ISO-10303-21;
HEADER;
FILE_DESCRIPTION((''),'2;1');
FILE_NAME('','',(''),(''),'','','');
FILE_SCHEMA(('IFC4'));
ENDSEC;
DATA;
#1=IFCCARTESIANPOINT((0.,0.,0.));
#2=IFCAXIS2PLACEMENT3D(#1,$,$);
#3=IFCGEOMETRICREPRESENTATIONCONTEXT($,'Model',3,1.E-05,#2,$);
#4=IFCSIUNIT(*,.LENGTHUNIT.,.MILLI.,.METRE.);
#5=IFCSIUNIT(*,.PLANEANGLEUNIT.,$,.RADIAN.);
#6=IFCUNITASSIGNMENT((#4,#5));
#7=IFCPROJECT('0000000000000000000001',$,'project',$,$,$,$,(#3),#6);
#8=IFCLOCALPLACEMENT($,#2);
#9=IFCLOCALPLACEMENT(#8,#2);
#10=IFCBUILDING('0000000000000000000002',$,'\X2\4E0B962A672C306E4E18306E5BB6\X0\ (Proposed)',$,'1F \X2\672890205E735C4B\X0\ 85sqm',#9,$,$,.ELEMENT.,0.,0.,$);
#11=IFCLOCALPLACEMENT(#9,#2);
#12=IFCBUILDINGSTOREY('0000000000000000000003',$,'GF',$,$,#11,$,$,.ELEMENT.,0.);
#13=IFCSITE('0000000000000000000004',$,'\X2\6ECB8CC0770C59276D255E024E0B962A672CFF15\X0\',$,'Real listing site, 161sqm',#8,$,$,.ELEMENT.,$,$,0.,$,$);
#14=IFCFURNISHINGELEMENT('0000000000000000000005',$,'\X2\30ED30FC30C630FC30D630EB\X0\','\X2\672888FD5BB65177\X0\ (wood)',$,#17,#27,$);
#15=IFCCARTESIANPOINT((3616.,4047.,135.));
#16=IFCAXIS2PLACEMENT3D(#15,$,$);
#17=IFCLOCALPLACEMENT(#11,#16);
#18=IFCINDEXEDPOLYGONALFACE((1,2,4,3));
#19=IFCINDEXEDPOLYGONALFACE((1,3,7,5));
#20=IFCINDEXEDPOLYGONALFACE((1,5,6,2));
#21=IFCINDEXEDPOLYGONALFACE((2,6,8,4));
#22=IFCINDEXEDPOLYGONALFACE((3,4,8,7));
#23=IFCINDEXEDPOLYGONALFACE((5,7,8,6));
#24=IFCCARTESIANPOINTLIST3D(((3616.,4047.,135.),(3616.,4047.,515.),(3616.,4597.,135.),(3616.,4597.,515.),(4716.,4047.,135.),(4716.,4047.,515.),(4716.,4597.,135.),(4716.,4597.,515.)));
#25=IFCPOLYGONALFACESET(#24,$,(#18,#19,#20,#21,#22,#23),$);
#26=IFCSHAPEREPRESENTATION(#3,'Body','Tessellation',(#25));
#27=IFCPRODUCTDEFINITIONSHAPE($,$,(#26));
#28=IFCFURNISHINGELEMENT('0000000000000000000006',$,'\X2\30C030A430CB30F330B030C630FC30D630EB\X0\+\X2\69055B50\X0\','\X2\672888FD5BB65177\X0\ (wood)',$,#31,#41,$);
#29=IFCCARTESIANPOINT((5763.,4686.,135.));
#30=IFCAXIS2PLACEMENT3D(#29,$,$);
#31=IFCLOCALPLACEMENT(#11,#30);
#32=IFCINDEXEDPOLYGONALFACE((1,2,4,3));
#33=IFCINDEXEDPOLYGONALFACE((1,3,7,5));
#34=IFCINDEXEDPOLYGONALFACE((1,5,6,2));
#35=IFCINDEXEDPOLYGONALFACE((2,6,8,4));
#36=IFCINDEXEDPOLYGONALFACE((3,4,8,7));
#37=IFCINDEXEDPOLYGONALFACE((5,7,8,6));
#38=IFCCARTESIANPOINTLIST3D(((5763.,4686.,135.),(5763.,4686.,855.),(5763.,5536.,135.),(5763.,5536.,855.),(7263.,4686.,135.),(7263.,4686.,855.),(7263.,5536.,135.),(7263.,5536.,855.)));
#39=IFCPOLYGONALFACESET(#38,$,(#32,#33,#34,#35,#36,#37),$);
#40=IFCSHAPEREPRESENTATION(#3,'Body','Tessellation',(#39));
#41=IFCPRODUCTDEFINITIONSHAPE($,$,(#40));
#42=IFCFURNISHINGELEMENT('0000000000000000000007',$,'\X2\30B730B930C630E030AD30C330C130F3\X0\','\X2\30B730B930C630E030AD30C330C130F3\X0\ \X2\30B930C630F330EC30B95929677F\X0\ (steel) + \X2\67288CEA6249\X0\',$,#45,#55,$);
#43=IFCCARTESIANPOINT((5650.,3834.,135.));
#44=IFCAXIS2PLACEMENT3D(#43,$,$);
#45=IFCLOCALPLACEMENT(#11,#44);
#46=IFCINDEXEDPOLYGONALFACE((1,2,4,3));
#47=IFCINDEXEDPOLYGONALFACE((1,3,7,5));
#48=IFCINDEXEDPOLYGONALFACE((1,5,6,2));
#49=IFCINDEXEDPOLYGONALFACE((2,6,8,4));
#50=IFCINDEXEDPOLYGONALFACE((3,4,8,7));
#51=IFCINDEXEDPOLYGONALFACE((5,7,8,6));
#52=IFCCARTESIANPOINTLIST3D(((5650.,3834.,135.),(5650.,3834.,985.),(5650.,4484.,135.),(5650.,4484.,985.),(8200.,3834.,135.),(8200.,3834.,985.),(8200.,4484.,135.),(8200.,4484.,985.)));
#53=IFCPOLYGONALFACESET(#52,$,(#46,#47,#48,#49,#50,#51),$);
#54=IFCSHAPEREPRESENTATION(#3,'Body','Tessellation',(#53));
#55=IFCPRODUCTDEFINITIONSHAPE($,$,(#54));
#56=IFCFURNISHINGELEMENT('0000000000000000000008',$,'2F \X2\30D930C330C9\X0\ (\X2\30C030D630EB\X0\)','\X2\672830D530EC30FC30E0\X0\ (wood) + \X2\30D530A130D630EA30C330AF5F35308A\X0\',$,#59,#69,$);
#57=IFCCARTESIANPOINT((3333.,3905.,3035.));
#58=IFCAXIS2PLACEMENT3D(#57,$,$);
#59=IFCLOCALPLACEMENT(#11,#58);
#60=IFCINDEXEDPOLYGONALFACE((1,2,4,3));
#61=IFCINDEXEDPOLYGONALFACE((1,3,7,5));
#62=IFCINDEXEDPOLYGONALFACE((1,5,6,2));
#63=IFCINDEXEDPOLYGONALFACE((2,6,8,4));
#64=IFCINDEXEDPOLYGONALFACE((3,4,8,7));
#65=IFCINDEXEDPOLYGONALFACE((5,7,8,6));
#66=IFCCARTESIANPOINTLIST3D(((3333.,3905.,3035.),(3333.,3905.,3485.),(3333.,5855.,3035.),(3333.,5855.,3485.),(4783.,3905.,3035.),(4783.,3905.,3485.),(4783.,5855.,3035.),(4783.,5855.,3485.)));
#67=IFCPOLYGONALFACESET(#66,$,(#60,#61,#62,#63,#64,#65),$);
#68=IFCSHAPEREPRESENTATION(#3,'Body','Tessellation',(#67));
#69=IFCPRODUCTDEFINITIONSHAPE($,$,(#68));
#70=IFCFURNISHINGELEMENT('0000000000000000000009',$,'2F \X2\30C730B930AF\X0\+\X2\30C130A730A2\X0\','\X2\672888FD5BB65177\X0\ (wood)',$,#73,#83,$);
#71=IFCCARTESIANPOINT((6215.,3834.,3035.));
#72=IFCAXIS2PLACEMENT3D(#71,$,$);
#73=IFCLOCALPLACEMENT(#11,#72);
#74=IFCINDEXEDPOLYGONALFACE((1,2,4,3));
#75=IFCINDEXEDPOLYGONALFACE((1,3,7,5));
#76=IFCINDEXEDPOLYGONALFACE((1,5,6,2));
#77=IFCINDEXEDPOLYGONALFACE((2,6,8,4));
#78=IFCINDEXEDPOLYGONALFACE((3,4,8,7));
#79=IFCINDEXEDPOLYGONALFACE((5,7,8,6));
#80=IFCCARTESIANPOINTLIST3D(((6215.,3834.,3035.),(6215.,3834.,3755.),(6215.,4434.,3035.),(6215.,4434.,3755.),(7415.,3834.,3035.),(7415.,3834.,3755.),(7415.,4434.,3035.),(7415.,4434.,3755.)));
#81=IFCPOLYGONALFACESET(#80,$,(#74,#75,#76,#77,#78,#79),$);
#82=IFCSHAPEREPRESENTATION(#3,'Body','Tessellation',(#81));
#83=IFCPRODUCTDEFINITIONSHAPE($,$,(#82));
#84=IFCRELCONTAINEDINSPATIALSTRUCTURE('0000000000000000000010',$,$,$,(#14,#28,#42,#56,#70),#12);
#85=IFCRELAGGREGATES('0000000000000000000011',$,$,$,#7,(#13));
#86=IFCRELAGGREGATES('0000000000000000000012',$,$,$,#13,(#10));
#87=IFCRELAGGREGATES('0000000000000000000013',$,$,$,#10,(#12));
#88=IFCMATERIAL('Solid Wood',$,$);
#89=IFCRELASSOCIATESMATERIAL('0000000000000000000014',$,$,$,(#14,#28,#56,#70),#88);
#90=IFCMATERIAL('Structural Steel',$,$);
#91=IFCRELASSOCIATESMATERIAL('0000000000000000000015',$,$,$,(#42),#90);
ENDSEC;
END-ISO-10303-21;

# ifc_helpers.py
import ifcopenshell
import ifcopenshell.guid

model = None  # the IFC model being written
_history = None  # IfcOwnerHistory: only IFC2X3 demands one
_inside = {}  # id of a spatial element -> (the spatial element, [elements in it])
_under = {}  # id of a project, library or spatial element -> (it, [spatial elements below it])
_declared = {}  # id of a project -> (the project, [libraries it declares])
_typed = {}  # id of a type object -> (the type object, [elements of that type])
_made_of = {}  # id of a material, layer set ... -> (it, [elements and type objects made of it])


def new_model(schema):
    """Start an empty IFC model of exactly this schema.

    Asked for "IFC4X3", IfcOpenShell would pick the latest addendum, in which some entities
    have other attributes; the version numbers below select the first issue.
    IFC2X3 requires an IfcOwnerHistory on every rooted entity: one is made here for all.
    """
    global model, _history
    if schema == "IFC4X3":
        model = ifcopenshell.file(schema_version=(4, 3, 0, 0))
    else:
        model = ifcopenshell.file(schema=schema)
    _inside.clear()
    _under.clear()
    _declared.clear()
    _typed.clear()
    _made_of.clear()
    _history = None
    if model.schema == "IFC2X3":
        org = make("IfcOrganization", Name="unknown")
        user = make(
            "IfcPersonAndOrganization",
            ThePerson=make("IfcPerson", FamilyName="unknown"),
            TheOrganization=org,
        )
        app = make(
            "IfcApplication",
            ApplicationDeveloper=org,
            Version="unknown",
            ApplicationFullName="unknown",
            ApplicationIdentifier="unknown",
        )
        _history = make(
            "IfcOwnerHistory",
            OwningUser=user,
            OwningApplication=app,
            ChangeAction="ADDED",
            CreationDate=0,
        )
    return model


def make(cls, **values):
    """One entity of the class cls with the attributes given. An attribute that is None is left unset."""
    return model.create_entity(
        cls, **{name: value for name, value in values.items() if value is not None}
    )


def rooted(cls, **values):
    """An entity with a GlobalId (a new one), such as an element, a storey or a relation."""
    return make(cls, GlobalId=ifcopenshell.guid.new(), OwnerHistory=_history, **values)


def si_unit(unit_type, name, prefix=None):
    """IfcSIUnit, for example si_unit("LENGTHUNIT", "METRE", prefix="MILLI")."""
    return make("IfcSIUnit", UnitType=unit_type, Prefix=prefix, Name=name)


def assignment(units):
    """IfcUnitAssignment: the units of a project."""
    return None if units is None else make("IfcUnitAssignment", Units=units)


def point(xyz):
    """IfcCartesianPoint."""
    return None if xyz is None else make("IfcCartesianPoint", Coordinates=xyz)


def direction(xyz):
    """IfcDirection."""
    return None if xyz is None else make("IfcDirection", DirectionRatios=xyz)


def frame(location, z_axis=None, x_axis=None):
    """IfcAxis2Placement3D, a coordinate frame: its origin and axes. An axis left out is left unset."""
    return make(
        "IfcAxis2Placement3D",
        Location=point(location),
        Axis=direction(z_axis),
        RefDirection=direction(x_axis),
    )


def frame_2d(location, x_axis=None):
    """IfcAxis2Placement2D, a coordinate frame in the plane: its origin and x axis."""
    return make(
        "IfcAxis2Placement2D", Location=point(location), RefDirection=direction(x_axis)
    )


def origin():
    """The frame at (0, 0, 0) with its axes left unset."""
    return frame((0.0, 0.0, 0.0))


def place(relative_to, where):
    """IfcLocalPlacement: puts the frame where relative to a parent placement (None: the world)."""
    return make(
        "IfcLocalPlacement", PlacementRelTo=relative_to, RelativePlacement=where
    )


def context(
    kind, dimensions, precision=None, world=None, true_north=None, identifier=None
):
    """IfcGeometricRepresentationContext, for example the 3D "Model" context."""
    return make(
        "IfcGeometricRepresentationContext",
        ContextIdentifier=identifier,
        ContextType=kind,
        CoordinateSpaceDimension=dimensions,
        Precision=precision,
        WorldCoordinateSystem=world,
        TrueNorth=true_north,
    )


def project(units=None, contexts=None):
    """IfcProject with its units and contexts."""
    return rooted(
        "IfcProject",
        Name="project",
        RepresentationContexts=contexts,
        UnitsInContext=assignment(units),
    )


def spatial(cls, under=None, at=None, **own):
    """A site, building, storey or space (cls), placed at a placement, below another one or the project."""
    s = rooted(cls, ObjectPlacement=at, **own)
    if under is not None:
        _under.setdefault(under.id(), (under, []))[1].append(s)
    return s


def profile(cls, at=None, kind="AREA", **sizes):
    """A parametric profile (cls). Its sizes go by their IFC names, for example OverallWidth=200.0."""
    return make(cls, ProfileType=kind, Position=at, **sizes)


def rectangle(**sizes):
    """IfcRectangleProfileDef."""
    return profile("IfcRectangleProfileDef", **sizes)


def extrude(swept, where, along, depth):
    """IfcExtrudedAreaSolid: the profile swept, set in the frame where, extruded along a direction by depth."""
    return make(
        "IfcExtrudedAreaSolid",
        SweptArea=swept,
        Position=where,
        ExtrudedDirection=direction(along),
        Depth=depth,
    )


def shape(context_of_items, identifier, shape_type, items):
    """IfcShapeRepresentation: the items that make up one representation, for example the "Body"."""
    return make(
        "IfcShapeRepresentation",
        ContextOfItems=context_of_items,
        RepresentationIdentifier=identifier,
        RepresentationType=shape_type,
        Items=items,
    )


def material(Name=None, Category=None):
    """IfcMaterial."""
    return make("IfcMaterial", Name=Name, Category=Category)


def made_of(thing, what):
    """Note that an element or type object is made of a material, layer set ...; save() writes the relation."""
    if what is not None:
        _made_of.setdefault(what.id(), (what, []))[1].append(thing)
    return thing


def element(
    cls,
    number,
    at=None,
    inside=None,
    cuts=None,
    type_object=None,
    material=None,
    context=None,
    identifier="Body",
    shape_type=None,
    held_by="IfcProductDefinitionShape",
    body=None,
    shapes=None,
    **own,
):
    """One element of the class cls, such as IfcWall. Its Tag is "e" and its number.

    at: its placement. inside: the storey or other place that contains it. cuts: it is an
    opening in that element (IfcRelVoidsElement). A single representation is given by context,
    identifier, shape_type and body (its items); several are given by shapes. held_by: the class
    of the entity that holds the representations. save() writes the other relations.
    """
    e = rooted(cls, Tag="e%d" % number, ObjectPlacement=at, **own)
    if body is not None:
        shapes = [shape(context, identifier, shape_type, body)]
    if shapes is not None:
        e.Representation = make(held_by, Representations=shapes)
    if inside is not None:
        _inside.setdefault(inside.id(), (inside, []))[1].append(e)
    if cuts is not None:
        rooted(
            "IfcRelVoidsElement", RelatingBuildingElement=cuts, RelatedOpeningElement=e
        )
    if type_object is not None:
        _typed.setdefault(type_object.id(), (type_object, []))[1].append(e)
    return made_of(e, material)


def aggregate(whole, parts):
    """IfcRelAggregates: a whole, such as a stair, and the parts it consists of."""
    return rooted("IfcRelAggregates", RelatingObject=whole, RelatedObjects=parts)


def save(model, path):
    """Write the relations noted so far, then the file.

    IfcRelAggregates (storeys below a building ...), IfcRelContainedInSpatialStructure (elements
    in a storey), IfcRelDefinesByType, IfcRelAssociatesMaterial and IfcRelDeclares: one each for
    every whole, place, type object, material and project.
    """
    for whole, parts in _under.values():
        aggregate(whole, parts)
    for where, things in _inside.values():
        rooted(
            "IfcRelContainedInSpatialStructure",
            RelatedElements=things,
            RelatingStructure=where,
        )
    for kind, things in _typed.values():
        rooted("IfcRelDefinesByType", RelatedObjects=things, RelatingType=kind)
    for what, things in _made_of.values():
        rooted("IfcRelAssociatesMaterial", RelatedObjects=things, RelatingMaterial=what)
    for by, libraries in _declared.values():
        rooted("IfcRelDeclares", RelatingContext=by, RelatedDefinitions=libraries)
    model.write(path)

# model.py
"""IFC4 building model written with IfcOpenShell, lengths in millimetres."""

from ifc_helpers import new_model, si_unit, frame, frame_2d, origin, place, context, project, spatial, rectangle, extrude, material, element, save


model = new_model("IFC4")

# Units and contexts
model_context = context("Model", 3, precision=1e-05, world=origin())
ifc_project = project(units=[si_unit("LENGTHUNIT", "METRE", prefix="MILLI"), si_unit("PLANEANGLEUNIT", "RADIAN")], contexts=[model_context])

# Site, building, storey
site_placement = place(None, origin())
site = spatial("IfcSite", under=ifc_project, at=site_placement, Name="滋賀県大津市下阪本５", ObjectType="Real listing site, 161sqm", CompositionType="ELEMENT", RefElevation=0.0)
building_placement = place(site_placement, origin())
building = spatial("IfcBuilding", under=site, at=building_placement, Name="下阪本の丘の家 (Proposed)", ObjectType="1F 木造平屋 85sqm", CompositionType="ELEMENT", ElevationOfRefHeight=0.0, ElevationOfTerrain=0.0)
storey_placement = place(building_placement, origin())
storey = spatial("IfcBuildingStorey", under=building, at=storey_placement, Name="GF", CompositionType="ELEMENT", Elevation=0.0)

# Shared definitions
ifc_material_1 = material(Name="Solid Wood")

# Shared definitions
ifc_material_2 = material(Name="Structural Steel")

# Furnishing elements
furnishing_1_placement = place(storey_placement, frame((3616.0, 4047.0, 135.0)))
element("IfcFurnishingElement", 1, at=furnishing_1_placement, inside=storey, material=ifc_material_1, Name="ローテーブル", Description="木製家具 (wood)", context=model_context, shape_type="SweptSolid", body=[
    extrude(rectangle(XDim=1100.0, YDim=550.0, at=frame_2d((550.0, 275.0))), frame((3616.0, 4047.0, 135.0)), (0.0, 0.0, 1.0), 380.0),
])
furnishing_2_placement = place(storey_placement, frame((5763.0, 4686.0, 135.0)))
element("IfcFurnishingElement", 2, at=furnishing_2_placement, inside=storey, material=ifc_material_1, Name="ダイニングテーブル+椅子", Description="木製家具 (wood)", context=model_context, shape_type="SweptSolid", body=[
    extrude(rectangle(XDim=1500.0, YDim=850.0, at=frame_2d((750.0, 425.0))), frame((5763.0, 4686.0, 135.0)), (0.0, 0.0, 1.0), 720.0),
])
furnishing_3_placement = place(storey_placement, frame((5650.0, 3834.0, 135.0)))
element("IfcFurnishingElement", 3, at=furnishing_3_placement, inside=storey, material=ifc_material_2, Name="システムキッチン", Description="システムキッチン ステンレス天板 (steel) + 木質扉", context=model_context, shape_type="SweptSolid", body=[
    extrude(rectangle(XDim=2550.0, YDim=650.0, at=frame_2d((1275.0, 325.0))), frame((5650.0, 3834.0, 135.0)), (0.0, 0.0, 1.0), 850.0),
])
furnishing_4_placement = place(storey_placement, frame((3333.0, 3905.0, 3035.0)))
element("IfcFurnishingElement", 4, at=furnishing_4_placement, inside=storey, material=ifc_material_1, Name="2F ベッド (ダブル)", Description="木フレーム (wood) + ファブリック張り", context=model_context, shape_type="SweptSolid", body=[
    extrude(rectangle(XDim=1450.0, YDim=1950.0, at=frame_2d((725.0, 975.0))), frame((3333.0, 3905.0, 3035.0)), (0.0, 0.0, 1.0), 450.0),
])
furnishing_5_placement = place(storey_placement, frame((6215.0, 3834.0, 3035.0)))
element("IfcFurnishingElement", 5, at=furnishing_5_placement, inside=storey, material=ifc_material_1, Name="2F デスク+チェア", Description="木製家具 (wood)", context=model_context, shape_type="SweptSolid", body=[
    extrude(rectangle(XDim=1200.0, YDim=600.0, at=frame_2d((600.0, 300.0))), frame((6215.0, 3834.0, 3035.0)), (0.0, 0.0, 1.0), 720.0),
])

save(model, "model.ifc")
